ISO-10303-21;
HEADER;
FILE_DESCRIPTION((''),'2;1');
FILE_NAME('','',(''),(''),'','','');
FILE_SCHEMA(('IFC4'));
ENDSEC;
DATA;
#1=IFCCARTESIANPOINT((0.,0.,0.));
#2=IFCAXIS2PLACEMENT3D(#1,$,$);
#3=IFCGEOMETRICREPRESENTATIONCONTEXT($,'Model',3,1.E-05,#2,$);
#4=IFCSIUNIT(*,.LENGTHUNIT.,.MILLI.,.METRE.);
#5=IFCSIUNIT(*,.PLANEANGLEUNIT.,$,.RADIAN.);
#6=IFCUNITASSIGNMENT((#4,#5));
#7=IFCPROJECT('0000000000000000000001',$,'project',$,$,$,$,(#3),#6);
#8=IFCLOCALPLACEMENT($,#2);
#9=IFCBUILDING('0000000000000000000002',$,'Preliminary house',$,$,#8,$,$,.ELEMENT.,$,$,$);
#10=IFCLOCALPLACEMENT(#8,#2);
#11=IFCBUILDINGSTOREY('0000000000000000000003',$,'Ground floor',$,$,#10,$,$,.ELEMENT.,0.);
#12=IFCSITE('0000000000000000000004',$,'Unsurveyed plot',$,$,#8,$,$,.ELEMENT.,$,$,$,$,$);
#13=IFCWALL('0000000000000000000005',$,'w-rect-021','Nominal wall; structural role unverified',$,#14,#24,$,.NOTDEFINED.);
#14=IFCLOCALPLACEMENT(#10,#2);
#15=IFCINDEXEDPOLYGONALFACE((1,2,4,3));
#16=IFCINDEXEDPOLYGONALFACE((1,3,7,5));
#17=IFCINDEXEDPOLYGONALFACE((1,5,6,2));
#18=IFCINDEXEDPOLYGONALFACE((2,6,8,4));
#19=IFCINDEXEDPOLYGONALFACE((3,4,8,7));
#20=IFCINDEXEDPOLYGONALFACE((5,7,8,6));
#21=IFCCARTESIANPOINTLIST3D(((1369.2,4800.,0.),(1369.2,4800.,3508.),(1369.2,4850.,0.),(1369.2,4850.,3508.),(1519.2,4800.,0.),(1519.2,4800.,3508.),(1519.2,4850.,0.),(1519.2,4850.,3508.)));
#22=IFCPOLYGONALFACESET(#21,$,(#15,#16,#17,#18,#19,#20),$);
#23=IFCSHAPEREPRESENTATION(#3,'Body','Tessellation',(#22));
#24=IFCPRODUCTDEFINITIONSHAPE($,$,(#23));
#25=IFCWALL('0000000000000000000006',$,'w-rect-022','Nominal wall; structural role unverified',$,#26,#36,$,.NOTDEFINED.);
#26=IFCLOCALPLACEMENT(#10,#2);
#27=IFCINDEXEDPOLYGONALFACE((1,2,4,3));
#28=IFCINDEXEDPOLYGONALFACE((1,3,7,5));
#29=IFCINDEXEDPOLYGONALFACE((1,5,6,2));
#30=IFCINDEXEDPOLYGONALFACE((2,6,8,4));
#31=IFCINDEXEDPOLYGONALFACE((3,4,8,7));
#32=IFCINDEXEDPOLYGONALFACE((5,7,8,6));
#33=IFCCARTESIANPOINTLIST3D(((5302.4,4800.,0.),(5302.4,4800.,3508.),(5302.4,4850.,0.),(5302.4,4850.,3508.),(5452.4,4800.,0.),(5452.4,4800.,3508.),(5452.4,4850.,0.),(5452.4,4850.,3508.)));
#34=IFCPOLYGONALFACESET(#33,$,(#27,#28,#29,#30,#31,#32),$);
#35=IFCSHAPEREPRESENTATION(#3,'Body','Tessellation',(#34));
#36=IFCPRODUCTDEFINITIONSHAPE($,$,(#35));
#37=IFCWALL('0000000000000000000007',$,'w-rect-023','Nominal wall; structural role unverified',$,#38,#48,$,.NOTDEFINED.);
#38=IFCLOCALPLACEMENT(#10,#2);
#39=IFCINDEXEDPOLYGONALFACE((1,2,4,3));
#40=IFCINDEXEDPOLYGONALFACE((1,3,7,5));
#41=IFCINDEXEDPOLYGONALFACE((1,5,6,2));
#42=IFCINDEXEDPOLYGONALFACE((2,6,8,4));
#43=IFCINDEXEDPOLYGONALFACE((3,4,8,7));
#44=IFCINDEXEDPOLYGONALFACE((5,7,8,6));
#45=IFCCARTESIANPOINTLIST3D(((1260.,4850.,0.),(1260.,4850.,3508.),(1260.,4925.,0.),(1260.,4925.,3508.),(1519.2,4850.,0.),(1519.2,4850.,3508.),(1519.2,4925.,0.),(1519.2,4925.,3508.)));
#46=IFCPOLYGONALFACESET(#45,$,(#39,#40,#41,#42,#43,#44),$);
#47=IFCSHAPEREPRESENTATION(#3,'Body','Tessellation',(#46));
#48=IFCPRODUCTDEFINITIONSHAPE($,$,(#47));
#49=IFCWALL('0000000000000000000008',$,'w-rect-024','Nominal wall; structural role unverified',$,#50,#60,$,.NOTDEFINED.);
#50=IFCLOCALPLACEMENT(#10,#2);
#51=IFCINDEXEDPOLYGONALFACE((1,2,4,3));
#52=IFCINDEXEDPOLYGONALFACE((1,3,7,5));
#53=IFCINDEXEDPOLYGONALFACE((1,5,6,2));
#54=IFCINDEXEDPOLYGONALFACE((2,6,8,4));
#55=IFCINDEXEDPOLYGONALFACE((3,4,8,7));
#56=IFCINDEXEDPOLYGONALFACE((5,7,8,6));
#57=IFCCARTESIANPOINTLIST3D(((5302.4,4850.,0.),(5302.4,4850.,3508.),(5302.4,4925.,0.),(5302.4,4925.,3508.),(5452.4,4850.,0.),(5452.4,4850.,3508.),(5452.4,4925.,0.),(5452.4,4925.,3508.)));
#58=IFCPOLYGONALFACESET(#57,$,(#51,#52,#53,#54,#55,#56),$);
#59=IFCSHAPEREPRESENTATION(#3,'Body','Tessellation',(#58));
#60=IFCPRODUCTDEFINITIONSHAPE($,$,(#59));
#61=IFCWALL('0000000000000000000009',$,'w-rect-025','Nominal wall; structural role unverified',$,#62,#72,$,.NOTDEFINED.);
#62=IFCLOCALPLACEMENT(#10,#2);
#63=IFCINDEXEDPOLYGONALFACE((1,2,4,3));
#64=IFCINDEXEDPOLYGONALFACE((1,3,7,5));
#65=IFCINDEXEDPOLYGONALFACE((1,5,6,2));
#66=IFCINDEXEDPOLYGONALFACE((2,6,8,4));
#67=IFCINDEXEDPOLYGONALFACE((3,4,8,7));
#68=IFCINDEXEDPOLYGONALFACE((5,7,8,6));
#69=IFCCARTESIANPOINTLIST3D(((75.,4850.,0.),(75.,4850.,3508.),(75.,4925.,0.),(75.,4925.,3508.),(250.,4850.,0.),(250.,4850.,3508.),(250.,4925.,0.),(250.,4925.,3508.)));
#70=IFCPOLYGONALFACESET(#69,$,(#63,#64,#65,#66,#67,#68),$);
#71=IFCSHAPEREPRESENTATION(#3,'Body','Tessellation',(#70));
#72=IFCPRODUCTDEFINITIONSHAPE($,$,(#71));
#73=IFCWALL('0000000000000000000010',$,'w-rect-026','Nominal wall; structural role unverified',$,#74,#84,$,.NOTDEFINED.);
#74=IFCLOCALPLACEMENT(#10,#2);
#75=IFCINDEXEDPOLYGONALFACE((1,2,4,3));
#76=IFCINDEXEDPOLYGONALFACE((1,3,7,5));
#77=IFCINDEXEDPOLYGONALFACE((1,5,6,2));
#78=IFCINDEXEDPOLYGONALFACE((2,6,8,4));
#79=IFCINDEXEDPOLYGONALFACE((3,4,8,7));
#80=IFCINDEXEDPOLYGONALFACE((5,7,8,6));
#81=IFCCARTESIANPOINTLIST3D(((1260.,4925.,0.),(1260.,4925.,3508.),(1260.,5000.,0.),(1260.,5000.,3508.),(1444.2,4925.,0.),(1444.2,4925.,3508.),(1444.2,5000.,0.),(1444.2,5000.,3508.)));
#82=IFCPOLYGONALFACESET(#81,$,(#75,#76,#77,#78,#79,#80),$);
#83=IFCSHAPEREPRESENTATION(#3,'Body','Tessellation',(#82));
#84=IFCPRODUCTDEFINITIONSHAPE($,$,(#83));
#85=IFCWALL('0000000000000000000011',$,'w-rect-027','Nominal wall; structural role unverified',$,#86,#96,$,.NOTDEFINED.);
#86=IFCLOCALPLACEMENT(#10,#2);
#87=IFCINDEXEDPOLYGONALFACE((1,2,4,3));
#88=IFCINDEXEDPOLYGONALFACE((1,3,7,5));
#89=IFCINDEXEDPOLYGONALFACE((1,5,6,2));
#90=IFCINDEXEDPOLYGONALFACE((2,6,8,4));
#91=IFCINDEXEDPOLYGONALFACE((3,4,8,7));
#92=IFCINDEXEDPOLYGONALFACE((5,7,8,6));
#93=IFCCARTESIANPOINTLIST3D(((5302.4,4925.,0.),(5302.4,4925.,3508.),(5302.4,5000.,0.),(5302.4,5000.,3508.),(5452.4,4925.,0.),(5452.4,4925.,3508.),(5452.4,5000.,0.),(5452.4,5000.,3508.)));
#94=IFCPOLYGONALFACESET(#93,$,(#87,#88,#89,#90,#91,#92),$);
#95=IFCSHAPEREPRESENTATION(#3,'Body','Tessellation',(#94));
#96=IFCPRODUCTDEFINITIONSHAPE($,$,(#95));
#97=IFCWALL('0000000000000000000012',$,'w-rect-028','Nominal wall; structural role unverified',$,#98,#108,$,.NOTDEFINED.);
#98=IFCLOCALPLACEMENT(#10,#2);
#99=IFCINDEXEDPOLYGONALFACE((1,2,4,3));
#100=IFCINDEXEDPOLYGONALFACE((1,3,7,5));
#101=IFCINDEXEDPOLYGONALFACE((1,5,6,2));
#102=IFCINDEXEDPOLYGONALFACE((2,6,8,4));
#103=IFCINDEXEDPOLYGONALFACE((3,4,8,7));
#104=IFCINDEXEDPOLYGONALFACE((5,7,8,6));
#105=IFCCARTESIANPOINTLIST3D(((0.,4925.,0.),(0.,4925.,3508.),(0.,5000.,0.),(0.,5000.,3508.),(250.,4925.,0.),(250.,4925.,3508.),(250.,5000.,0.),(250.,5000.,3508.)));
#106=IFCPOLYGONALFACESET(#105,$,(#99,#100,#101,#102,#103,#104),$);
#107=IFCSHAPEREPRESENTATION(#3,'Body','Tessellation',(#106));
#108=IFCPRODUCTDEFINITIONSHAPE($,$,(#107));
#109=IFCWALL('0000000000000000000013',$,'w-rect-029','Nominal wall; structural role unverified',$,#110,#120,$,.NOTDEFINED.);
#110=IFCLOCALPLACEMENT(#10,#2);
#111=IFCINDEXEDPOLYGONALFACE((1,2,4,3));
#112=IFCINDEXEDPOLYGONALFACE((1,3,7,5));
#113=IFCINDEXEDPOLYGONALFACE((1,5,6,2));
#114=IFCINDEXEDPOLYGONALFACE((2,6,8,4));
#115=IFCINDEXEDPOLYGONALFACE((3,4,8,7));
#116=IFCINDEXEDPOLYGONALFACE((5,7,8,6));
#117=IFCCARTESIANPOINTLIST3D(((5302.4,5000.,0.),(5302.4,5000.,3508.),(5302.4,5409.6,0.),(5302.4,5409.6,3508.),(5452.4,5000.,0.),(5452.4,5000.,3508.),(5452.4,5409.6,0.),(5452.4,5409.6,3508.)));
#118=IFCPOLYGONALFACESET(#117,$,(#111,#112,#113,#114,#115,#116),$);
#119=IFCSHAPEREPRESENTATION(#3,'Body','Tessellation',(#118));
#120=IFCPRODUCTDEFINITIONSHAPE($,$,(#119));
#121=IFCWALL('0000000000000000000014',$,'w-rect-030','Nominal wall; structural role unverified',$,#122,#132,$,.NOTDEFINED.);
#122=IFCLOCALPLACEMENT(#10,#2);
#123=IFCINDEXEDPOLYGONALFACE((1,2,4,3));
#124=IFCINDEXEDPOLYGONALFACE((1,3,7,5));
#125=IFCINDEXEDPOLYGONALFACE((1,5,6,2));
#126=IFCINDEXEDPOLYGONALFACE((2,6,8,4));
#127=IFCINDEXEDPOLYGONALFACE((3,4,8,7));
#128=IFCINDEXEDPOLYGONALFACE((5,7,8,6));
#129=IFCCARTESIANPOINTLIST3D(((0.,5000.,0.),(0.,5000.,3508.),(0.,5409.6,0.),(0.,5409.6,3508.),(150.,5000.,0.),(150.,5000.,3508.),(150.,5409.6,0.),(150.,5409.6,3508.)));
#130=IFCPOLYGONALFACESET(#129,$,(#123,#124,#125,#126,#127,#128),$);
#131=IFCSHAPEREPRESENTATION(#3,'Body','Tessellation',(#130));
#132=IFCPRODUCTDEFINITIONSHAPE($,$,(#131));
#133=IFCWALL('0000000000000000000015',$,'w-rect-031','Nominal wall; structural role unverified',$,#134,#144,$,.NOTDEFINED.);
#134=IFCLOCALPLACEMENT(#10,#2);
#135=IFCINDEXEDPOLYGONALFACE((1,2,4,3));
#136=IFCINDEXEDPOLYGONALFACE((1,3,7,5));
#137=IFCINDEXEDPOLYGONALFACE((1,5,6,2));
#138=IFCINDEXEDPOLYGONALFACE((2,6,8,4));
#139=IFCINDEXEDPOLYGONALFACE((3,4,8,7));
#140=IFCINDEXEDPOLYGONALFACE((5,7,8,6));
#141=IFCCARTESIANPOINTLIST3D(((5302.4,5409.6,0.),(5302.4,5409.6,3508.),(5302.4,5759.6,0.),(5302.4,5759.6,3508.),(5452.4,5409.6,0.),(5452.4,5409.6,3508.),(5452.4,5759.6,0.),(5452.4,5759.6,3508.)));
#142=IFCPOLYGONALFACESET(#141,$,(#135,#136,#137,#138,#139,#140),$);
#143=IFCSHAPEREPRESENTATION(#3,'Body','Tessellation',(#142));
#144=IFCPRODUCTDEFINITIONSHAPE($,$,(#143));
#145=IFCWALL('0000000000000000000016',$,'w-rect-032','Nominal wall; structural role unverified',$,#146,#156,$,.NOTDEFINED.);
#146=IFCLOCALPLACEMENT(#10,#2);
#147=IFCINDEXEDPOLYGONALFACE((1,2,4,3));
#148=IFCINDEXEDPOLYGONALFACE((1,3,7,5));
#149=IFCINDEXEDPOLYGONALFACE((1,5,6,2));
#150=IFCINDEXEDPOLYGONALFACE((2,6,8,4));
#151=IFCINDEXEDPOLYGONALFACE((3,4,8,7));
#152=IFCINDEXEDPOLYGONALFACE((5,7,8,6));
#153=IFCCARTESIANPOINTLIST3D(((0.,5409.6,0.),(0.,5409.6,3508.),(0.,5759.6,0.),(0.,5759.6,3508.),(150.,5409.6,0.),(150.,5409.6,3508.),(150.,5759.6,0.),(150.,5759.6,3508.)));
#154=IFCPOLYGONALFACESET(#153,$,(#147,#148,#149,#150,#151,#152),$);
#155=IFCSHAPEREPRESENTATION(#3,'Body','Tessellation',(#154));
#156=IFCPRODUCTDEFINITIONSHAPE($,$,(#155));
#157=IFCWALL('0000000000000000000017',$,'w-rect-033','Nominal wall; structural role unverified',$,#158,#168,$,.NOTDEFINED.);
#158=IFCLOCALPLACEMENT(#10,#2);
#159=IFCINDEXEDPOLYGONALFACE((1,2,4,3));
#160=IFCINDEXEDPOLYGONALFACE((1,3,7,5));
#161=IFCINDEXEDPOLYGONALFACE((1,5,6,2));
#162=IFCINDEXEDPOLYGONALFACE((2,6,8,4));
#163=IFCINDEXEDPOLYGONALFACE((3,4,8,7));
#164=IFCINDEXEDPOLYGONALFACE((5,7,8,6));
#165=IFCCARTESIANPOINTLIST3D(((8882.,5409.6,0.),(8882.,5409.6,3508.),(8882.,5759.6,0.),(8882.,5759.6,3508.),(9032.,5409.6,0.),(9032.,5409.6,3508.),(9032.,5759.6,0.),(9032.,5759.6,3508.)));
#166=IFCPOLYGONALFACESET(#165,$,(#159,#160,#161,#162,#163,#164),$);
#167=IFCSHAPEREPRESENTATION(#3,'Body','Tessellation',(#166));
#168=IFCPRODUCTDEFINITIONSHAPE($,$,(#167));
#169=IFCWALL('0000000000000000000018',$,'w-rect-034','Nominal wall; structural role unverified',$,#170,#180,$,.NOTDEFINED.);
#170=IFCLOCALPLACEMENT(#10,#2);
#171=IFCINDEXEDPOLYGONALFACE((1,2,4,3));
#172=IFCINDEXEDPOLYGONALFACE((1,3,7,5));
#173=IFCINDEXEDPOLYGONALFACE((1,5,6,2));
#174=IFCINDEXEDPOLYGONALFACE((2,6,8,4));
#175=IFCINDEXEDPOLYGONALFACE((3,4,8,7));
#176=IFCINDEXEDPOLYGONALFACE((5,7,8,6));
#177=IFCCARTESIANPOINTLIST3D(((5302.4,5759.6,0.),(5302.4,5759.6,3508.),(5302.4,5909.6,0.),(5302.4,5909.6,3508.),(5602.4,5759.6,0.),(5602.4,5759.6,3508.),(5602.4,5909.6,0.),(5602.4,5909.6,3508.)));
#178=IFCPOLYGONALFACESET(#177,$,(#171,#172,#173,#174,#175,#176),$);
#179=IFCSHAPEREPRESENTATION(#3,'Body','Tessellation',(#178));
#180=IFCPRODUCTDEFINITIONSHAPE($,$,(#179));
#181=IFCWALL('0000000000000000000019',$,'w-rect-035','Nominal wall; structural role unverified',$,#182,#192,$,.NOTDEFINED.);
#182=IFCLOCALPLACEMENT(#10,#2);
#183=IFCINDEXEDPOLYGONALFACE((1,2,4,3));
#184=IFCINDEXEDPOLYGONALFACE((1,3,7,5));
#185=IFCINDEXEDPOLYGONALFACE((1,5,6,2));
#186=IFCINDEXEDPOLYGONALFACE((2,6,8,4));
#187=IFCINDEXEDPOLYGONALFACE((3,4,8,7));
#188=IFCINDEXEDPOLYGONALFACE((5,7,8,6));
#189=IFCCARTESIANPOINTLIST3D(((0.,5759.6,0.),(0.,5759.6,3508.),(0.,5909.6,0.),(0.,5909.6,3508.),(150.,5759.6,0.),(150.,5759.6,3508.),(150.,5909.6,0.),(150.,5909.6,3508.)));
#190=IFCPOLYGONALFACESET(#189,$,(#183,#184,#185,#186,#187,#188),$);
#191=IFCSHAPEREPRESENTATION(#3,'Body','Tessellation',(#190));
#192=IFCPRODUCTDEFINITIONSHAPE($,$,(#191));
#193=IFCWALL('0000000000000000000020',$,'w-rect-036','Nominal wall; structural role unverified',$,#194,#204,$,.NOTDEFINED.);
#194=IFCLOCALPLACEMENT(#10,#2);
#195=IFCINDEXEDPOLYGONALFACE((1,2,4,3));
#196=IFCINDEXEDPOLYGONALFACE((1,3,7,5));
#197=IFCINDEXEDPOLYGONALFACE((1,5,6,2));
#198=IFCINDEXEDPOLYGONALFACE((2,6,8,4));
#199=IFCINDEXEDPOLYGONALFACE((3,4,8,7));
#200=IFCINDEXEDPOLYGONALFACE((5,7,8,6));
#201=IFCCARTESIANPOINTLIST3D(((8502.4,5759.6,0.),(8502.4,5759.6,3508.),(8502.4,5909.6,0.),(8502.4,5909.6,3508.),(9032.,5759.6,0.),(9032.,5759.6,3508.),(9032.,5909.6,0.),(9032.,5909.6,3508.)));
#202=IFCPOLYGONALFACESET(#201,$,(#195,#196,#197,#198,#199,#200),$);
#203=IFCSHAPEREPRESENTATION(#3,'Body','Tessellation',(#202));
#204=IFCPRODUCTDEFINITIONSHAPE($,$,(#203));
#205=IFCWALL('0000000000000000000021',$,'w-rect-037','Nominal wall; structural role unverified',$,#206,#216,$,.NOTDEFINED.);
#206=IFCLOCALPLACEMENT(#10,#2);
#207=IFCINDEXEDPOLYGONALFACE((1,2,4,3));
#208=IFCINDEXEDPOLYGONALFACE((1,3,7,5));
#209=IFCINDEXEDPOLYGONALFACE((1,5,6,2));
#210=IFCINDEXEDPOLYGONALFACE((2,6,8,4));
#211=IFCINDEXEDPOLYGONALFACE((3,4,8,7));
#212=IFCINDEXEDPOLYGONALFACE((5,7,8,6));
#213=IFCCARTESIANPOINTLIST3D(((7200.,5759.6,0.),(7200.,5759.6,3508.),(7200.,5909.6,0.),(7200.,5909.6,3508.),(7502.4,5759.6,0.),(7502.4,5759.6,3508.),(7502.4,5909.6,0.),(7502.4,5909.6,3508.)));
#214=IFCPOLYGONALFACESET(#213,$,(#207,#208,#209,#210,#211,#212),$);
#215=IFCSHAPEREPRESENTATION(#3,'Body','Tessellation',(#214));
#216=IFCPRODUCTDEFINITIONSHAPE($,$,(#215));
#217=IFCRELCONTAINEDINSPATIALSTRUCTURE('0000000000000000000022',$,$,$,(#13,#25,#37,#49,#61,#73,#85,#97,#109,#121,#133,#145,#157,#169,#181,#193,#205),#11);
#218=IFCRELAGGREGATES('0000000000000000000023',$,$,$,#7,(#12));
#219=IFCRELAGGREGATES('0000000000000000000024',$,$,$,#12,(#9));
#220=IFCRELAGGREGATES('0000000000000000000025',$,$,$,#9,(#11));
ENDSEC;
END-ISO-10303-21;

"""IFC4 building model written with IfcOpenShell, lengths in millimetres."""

from ifc_helpers import new_model, si_unit, origin, place, context, project, spatial, polyline, outline, extrude, element, save


model = new_model("IFC4")

# Units and contexts
model_context = context("Model", 3, precision=1e-05, world=origin())
ifc_project = project(units=[si_unit("LENGTHUNIT", "METRE", prefix="MILLI"), si_unit("PLANEANGLEUNIT", "RADIAN")], contexts=[model_context])

# Site, building, storey
placement_1 = place(None, origin())
site = spatial("IfcSite", under=ifc_project, at=placement_1, Name="Unsurveyed plot", CompositionType="ELEMENT")
building = spatial("IfcBuilding", under=site, at=placement_1, Name="Preliminary house", CompositionType="ELEMENT")
placement_2 = place(placement_1, origin())
storey = spatial("IfcBuildingStorey", under=building, at=placement_2, Name="Ground floor", CompositionType="ELEMENT", Elevation=0.0)

# Walls
element("IfcWall", 1, at=placement_2, inside=storey, Name="w-rect-021", Description="Nominal wall; structural role unverified", PredefinedType="NOTDEFINED", context=model_context, shape_type="SweptSolid", body=[
    extrude(outline(polyline([(1369.2, 4800.0), (1519.2, 4800.0), (1519.2, 4850.0), (1369.2, 4850.0), (1369.2, 4800.0)])), origin(), (0.0, 0.0, 1.0), 3508.0),
])
element("IfcWall", 2, at=placement_2, inside=storey, Name="w-rect-022", Description="Nominal wall; structural role unverified", PredefinedType="NOTDEFINED", context=model_context, shape_type="SweptSolid", body=[
    extrude(outline(polyline([(5302.4, 4800.0), (5452.4, 4800.0), (5452.4, 4850.0), (5302.4, 4850.0), (5302.4, 4800.0)])), origin(), (0.0, 0.0, 1.0), 3508.0),
])
element("IfcWall", 3, at=placement_2, inside=storey, Name="w-rect-023", Description="Nominal wall; structural role unverified", PredefinedType="NOTDEFINED", context=model_context, shape_type="SweptSolid", body=[
    extrude(outline(polyline([(1260.0, 4850.0), (1519.2, 4850.0), (1519.2, 4925.0), (1260.0, 4925.0), (1260.0, 4850.0)])), origin(), (0.0, 0.0, 1.0), 3508.0),
])
element("IfcWall", 4, at=placement_2, inside=storey, Name="w-rect-024", Description="Nominal wall; structural role unverified", PredefinedType="NOTDEFINED", context=model_context, shape_type="SweptSolid", body=[
    extrude(outline(polyline([(5302.4, 4850.0), (5452.4, 4850.0), (5452.4, 4925.0), (5302.4, 4925.0), (5302.4, 4850.0)])), origin(), (0.0, 0.0, 1.0), 3508.0),
])
element("IfcWall", 5, at=placement_2, inside=storey, Name="w-rect-025", Description="Nominal wall; structural role unverified", PredefinedType="NOTDEFINED", context=model_context, shape_type="SweptSolid", body=[
    extrude(outline(polyline([(75.0, 4850.0), (250.0, 4850.0), (250.0, 4925.0), (75.0, 4925.0), (75.0, 4850.0)])), origin(), (0.0, 0.0, 1.0), 3508.0),
])
element("IfcWall", 6, at=placement_2, inside=storey, Name="w-rect-026", Description="Nominal wall; structural role unverified", PredefinedType="NOTDEFINED", context=model_context, shape_type="SweptSolid", body=[
    extrude(outline(polyline([(1260.0, 4925.0), (1444.2, 4925.0), (1444.2, 5000.0), (1260.0, 5000.0), (1260.0, 4925.0)])), origin(), (0.0, 0.0, 1.0), 3508.0),
])
element("IfcWall", 7, at=placement_2, inside=storey, Name="w-rect-027", Description="Nominal wall; structural role unverified", PredefinedType="NOTDEFINED", context=model_context, shape_type="SweptSolid", body=[
    extrude(outline(polyline([(5302.4, 4925.0), (5452.4, 4925.0), (5452.4, 5000.0), (5302.4, 5000.0), (5302.4, 4925.0)])), origin(), (0.0, 0.0, 1.0), 3508.0),
])
element("IfcWall", 8, at=placement_2, inside=storey, Name="w-rect-028", Description="Nominal wall; structural role unverified", PredefinedType="NOTDEFINED", context=model_context, shape_type="SweptSolid", body=[
    extrude(outline(polyline([(0.0, 4925.0), (250.0, 4925.0), (250.0, 5000.0), (0.0, 5000.0), (0.0, 4925.0)])), origin(), (0.0, 0.0, 1.0), 3508.0),
])
element("IfcWall", 9, at=placement_2, inside=storey, Name="w-rect-029", Description="Nominal wall; structural role unverified", PredefinedType="NOTDEFINED", context=model_context, shape_type="SweptSolid", body=[
    extrude(outline(polyline([(5302.4, 5000.0), (5452.4, 5000.0), (5452.4, 5409.6), (5302.4, 5409.6), (5302.4, 5000.0)])), origin(), (0.0, 0.0, 1.0), 3508.0),
])
element("IfcWall", 10, at=placement_2, inside=storey, Name="w-rect-030", Description="Nominal wall; structural role unverified", PredefinedType="NOTDEFINED", context=model_context, shape_type="SweptSolid", body=[
    extrude(outline(polyline([(0.0, 5000.0), (150.0, 5000.0), (150.0, 5409.6), (0.0, 5409.6), (0.0, 5000.0)])), origin(), (0.0, 0.0, 1.0), 3508.0),
])
element("IfcWall", 11, at=placement_2, inside=storey, Name="w-rect-031", Description="Nominal wall; structural role unverified", PredefinedType="NOTDEFINED", context=model_context, shape_type="SweptSolid", body=[
    extrude(outline(polyline([(5302.4, 5409.6), (5452.4, 5409.6), (5452.4, 5759.6), (5302.4, 5759.6), (5302.4, 5409.6)])), origin(), (0.0, 0.0, 1.0), 3508.0),
])
element("IfcWall", 12, at=placement_2, inside=storey, Name="w-rect-032", Description="Nominal wall; structural role unverified", PredefinedType="NOTDEFINED", context=model_context, shape_type="SweptSolid", body=[
    extrude(outline(polyline([(0.0, 5409.6), (150.0, 5409.6), (150.0, 5759.6), (0.0, 5759.6), (0.0, 5409.6)])), origin(), (0.0, 0.0, 1.0), 3508.0),
])
element("IfcWall", 13, at=placement_2, inside=storey, Name="w-rect-033", Description="Nominal wall; structural role unverified", PredefinedType="NOTDEFINED", context=model_context, shape_type="SweptSolid", body=[
    extrude(outline(polyline([(8882.0, 5409.6), (9032.0, 5409.6), (9032.0, 5759.6), (8882.0, 5759.6), (8882.0, 5409.6)])), origin(), (0.0, 0.0, 1.0), 3508.0),
])
element("IfcWall", 14, at=placement_2, inside=storey, Name="w-rect-034", Description="Nominal wall; structural role unverified", PredefinedType="NOTDEFINED", context=model_context, shape_type="SweptSolid", body=[
    extrude(outline(polyline([(5302.4, 5759.6), (5602.4, 5759.6), (5602.4, 5909.6), (5302.4, 5909.6), (5302.4, 5759.6)])), origin(), (0.0, 0.0, 1.0), 3508.0),
])
element("IfcWall", 15, at=placement_2, inside=storey, Name="w-rect-035", Description="Nominal wall; structural role unverified", PredefinedType="NOTDEFINED", context=model_context, shape_type="SweptSolid", body=[
    extrude(outline(polyline([(0.0, 5759.6), (150.0, 5759.6), (150.0, 5909.6), (0.0, 5909.6), (0.0, 5759.6)])), origin(), (0.0, 0.0, 1.0), 3508.0),
])
element("IfcWall", 16, at=placement_2, inside=storey, Name="w-rect-036", Description="Nominal wall; structural role unverified", PredefinedType="NOTDEFINED", context=model_context, shape_type="SweptSolid", body=[
    extrude(outline(polyline([(8502.4, 5759.6), (9032.0, 5759.6), (9032.0, 5909.6), (8502.4, 5909.6), (8502.4, 5759.6)])), origin(), (0.0, 0.0, 1.0), 3508.0),
])
element("IfcWall", 17, at=placement_2, inside=storey, Name="w-rect-037", Description="Nominal wall; structural role unverified", PredefinedType="NOTDEFINED", context=model_context, shape_type="SweptSolid", body=[
    extrude(outline(polyline([(7200.0, 5759.6), (7502.4, 5759.6), (7502.4, 5909.6), (7200.0, 5909.6), (7200.0, 5759.6)])), origin(), (0.0, 0.0, 1.0), 3508.0),
])

save(model, "model.ifc")
